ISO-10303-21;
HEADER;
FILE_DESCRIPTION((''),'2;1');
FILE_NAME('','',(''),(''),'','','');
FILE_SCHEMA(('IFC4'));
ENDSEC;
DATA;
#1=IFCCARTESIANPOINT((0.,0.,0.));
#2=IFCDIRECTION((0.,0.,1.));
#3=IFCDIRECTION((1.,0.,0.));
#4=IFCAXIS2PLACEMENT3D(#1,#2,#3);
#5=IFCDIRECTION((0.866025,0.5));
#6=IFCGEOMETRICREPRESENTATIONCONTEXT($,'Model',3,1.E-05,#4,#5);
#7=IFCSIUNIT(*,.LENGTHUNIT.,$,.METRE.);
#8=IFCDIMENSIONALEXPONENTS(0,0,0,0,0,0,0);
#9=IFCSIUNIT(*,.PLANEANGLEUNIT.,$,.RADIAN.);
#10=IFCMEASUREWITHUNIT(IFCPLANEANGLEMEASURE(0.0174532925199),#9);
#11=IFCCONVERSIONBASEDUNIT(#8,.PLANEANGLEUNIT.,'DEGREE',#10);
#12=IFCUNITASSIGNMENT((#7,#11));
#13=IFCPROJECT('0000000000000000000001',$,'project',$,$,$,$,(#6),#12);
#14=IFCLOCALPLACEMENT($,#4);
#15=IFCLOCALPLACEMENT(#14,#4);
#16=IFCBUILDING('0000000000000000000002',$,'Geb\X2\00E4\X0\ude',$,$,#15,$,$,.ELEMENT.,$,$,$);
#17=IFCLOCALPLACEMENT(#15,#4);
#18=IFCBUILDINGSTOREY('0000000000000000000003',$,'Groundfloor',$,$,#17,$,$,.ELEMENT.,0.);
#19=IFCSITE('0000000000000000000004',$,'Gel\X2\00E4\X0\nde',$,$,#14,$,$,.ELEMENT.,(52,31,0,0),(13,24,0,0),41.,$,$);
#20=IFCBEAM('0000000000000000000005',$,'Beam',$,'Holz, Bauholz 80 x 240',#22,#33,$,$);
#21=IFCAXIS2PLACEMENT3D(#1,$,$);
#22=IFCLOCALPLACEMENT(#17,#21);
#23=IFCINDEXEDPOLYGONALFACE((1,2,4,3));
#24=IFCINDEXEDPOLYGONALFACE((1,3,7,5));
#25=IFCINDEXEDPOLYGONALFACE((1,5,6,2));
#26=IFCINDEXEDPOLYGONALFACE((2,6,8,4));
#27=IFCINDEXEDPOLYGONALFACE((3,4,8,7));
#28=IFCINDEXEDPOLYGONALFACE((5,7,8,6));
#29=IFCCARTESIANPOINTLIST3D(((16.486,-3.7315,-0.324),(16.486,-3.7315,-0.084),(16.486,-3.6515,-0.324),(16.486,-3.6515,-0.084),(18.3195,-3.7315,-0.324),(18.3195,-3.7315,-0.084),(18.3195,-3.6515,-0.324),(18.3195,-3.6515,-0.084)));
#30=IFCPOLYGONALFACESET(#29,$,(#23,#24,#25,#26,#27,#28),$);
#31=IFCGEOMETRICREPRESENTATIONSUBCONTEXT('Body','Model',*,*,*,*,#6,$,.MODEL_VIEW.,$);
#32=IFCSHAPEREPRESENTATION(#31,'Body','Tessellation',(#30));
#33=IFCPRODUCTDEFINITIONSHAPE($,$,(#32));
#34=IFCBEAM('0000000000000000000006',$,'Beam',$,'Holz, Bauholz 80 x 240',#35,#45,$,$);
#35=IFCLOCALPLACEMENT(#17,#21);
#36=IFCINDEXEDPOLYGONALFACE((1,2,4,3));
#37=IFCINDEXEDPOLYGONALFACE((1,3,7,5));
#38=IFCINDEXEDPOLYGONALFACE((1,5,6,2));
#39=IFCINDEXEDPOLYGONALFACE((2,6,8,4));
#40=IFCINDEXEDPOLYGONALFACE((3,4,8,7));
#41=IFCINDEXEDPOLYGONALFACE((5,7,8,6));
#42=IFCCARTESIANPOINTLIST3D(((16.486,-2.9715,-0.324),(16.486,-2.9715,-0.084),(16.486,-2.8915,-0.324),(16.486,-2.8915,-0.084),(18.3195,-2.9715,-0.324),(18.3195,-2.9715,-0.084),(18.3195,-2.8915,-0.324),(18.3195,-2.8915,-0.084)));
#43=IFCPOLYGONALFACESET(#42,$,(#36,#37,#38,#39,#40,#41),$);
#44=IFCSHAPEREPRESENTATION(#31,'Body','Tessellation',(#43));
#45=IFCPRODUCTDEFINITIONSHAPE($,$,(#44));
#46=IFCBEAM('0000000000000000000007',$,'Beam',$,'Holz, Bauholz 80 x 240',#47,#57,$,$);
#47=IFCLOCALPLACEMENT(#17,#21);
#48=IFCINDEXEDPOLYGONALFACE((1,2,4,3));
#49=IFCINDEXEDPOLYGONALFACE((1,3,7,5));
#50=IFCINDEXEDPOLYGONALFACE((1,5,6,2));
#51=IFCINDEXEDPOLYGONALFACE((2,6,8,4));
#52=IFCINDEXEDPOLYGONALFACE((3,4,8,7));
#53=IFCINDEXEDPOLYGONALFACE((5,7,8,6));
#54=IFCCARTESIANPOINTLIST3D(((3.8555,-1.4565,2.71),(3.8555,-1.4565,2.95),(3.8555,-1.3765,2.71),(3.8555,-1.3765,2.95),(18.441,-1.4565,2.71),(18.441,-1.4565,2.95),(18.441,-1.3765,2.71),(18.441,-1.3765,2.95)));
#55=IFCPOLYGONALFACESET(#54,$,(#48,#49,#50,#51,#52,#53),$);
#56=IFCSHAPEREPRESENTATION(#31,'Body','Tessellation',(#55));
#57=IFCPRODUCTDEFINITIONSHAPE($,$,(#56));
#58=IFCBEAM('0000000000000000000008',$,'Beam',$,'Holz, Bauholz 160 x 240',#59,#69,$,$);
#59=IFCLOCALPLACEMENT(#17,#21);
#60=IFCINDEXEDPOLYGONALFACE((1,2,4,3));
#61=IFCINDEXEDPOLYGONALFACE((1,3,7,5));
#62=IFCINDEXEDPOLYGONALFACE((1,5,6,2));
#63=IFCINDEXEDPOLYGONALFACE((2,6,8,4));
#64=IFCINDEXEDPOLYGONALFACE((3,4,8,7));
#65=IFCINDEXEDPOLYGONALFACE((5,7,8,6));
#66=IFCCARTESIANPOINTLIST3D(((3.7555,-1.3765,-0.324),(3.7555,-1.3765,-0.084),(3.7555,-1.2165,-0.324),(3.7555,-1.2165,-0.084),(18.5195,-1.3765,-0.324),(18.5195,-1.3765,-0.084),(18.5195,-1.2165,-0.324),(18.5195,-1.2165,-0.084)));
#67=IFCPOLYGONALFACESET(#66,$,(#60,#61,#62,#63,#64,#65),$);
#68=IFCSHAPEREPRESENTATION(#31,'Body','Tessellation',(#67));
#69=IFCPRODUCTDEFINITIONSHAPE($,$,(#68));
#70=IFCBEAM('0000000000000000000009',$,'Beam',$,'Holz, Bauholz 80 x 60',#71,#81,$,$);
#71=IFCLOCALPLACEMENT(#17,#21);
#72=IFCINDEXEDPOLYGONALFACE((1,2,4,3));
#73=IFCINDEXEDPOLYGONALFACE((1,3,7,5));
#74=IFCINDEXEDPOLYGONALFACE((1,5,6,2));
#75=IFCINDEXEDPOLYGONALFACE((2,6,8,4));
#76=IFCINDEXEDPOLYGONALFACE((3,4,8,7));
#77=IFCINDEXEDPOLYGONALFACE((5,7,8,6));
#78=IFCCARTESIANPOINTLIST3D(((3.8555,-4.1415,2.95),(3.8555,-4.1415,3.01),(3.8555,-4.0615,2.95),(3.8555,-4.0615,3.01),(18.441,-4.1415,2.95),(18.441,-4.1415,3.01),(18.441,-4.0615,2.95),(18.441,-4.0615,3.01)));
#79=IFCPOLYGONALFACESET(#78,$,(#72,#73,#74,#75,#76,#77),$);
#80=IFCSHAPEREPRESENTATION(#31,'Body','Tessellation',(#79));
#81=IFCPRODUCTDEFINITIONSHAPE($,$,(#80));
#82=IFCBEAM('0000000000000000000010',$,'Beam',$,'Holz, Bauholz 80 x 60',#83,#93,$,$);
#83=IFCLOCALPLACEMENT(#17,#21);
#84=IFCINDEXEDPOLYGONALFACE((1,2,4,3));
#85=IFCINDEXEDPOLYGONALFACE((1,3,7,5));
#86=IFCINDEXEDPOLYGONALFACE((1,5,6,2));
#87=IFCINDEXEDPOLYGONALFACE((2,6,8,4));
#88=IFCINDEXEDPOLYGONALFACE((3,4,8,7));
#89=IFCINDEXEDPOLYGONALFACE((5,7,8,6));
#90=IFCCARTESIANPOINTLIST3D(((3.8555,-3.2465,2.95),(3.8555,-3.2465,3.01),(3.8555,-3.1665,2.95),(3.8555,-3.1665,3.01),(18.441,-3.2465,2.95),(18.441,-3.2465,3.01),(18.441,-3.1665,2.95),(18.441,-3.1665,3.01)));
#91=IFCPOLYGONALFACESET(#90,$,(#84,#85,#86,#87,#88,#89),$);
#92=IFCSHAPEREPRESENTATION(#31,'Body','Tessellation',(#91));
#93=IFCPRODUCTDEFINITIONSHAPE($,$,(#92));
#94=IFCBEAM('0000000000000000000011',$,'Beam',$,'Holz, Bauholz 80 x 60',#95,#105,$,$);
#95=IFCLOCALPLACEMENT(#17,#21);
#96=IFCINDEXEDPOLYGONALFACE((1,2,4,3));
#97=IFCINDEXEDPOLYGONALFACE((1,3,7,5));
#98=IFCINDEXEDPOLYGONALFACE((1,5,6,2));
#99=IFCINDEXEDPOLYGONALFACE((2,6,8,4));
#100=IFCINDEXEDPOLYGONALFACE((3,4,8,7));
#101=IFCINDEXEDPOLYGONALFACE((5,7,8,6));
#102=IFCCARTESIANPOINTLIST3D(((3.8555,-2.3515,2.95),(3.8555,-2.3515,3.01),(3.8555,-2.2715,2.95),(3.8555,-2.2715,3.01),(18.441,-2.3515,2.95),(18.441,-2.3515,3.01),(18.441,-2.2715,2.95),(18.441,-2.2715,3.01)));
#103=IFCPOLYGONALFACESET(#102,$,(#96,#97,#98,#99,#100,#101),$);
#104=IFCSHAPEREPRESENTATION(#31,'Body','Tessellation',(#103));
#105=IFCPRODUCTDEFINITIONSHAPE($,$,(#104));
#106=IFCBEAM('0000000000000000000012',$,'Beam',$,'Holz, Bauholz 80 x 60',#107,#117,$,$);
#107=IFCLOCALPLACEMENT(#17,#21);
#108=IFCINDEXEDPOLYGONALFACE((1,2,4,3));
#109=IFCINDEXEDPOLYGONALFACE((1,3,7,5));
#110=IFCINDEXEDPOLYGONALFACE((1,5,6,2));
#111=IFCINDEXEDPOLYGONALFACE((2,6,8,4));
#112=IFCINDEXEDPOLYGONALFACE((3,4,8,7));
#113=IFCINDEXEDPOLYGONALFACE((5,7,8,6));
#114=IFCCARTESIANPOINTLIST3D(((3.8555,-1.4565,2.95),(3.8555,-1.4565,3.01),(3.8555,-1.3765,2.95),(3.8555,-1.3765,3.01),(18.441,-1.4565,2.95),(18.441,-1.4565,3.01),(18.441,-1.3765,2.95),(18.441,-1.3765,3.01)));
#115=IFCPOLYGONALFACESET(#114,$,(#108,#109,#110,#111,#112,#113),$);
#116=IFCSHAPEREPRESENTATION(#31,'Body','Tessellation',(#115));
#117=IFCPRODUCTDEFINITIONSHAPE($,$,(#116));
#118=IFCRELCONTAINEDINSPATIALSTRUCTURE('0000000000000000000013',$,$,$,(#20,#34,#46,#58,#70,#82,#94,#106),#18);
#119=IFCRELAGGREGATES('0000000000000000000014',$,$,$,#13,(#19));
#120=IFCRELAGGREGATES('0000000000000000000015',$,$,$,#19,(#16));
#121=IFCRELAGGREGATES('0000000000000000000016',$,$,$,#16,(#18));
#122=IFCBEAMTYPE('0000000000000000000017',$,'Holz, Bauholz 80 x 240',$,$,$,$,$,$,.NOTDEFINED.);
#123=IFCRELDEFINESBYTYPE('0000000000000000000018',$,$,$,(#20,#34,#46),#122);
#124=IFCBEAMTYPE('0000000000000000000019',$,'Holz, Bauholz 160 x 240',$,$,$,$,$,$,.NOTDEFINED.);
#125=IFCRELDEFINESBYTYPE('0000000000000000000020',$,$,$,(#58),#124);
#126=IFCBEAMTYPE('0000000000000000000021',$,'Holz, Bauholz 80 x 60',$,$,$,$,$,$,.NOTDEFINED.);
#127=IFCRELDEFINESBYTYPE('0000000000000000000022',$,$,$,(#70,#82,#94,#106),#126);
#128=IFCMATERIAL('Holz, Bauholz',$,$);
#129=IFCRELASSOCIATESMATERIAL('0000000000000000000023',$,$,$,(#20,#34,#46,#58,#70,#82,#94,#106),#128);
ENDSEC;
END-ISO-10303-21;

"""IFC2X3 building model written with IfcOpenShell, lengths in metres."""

from ifc_helpers import new_model, entity, si_unit, converted_unit, direction, frame, frame_2d, origin_with_axes, place, context, subcontext, project, spatial, rectangle, extrude, material, type_object, element, save


model = new_model("IFC2X3")

# Units and contexts
model_context = context("Model", 3, precision=1e-05, world=origin_with_axes(), true_north=direction((0.866025, 0.5)))
body_context = subcontext(model_context, "Body", "Model", "MODEL_VIEW")
ifc_project = project(units=[si_unit("LENGTHUNIT", "METRE"), converted_unit("PLANEANGLEUNIT", "DEGREE", entity("IfcPlaneAngleMeasure", 0.0174532925199), si_unit("PLANEANGLEUNIT", "RADIAN"), dimensions=[0, 0, 0, 0, 0, 0, 0])], contexts=[model_context])

# Site, building, storey
site_placement = place(None, origin_with_axes())
site = spatial("IfcSite", under=ifc_project, at=site_placement, Name="Gelände", CompositionType="ELEMENT", RefLatitude=(52, 31, 0, 0), RefLongitude=(13, 24, 0, 0), RefElevation=41.0)
building_placement = place(site_placement, origin_with_axes())
building = spatial("IfcBuilding", under=site, at=building_placement, Name="Gebäude", CompositionType="ELEMENT")
storey_placement = place(building_placement, origin_with_axes())
storey = spatial("IfcBuildingStorey", under=building, at=storey_placement, Name="Groundfloor", CompositionType="ELEMENT", Elevation=0.0)

# Shared definitions
ifc_material_1 = material(Name="Holz, Bauholz")

# Beams
beam_type_1 = type_object("IfcBeamType", Name="Holz, Bauholz 80 x 240", PredefinedType="NOTDEFINED")
for number, where, z_axis, x_axis, name in (
    (1, (18.3195, -3.6915, -0.084), (0.0, 0.0, 1.0), (0.0, 1.0, 0.0), "Beam"),
    (2, (18.3195, -2.9315, -0.084), (0.0, 0.0, 1.0), (0.0, 1.0, 0.0), "Beam"),
):
    element("IfcBeam", number, at=place(storey_placement, frame(where, z_axis=z_axis, x_axis=x_axis)), inside=storey, type_object=beam_type_1, material=ifc_material_1, Name=name, ObjectType="Holz, Bauholz 80 x 240", context=body_context, shape_type="SweptSolid", body=[
        extrude(rectangle(XDim=0.24, YDim=0.08, at=frame_2d((-0.12, 0.0), x_axis=(1.0, 0.0))), frame((0.0, 0.0, 0.0), z_axis=(0.0, 1.0, 0.0), x_axis=(0.0, 0.0, 1.0)), (0.0, 0.0, 1.0), 1.8335),
    ])
beam_1_placement = place(storey_placement, frame((18.441, -1.4165, 2.95), z_axis=(0.0, 0.0, 1.0), x_axis=(0.0, 1.0, 0.0)))
element("IfcBeam", 3, at=beam_1_placement, inside=storey, type_object=beam_type_1, material=ifc_material_1, Name="Beam", ObjectType="Holz, Bauholz 80 x 240", context=body_context, shape_type="SweptSolid", body=[
    extrude(rectangle(XDim=0.24, YDim=0.08, at=frame_2d((-0.12, 0.0), x_axis=(1.0, 0.0))), frame((0.0, 0.0, 0.0), z_axis=(0.0, 1.0, 0.0), x_axis=(0.0, 0.0, 1.0)), (0.0, 0.0, 1.0), 14.5855),
])
beam_type_2 = type_object("IfcBeamType", Name="Holz, Bauholz 160 x 240", PredefinedType="NOTDEFINED")
beam_2_placement = place(storey_placement, frame((18.5195, -1.2965, -0.084), z_axis=(0.0, 0.0, 1.0), x_axis=(0.0, 1.0, 0.0)))
element("IfcBeam", 4, at=beam_2_placement, inside=storey, type_object=beam_type_2, material=ifc_material_1, Name="Beam", ObjectType="Holz, Bauholz 160 x 240", context=body_context, shape_type="SweptSolid", body=[
    extrude(rectangle(XDim=0.24, YDim=0.16, at=frame_2d((-0.12, 0.0), x_axis=(1.0, 0.0))), frame((0.0, 0.0, 0.0), z_axis=(0.0, 1.0, 0.0), x_axis=(0.0, 0.0, 1.0)), (0.0, 0.0, 1.0), 14.764),
])
beam_type_3 = type_object("IfcBeamType", Name="Holz, Bauholz 80 x 60", PredefinedType="NOTDEFINED")
for number, where, z_axis, x_axis, name in (
    (5, (18.441, -4.1015, 3.01), (0.0, 0.0, 1.0), (0.0, 1.0, 0.0), "Beam"),
    (6, (18.441, -3.2065, 3.01), (0.0, 0.0, 1.0), (0.0, 1.0, 0.0), "Beam"),
    (7, (18.441, -2.3115, 3.01), (0.0, 0.0, 1.0), (0.0, 1.0, 0.0), "Beam"),
    (8, (18.441, -1.4165, 3.01), (0.0, 0.0, 1.0), (0.0, 1.0, 0.0), "Beam"),
):
    element("IfcBeam", number, at=place(storey_placement, frame(where, z_axis=z_axis, x_axis=x_axis)), inside=storey, type_object=beam_type_3, material=ifc_material_1, Name=name, ObjectType="Holz, Bauholz 80 x 60", context=body_context, shape_type="SweptSolid", body=[
        extrude(rectangle(XDim=0.06, YDim=0.08, at=frame_2d((-0.03, 0.0), x_axis=(1.0, 0.0))), frame((0.0, 0.0, 0.0), z_axis=(0.0, 1.0, 0.0), x_axis=(0.0, 0.0, 1.0)), (0.0, 0.0, 1.0), 14.5855),
    ])

save(model, "model.ifc")
